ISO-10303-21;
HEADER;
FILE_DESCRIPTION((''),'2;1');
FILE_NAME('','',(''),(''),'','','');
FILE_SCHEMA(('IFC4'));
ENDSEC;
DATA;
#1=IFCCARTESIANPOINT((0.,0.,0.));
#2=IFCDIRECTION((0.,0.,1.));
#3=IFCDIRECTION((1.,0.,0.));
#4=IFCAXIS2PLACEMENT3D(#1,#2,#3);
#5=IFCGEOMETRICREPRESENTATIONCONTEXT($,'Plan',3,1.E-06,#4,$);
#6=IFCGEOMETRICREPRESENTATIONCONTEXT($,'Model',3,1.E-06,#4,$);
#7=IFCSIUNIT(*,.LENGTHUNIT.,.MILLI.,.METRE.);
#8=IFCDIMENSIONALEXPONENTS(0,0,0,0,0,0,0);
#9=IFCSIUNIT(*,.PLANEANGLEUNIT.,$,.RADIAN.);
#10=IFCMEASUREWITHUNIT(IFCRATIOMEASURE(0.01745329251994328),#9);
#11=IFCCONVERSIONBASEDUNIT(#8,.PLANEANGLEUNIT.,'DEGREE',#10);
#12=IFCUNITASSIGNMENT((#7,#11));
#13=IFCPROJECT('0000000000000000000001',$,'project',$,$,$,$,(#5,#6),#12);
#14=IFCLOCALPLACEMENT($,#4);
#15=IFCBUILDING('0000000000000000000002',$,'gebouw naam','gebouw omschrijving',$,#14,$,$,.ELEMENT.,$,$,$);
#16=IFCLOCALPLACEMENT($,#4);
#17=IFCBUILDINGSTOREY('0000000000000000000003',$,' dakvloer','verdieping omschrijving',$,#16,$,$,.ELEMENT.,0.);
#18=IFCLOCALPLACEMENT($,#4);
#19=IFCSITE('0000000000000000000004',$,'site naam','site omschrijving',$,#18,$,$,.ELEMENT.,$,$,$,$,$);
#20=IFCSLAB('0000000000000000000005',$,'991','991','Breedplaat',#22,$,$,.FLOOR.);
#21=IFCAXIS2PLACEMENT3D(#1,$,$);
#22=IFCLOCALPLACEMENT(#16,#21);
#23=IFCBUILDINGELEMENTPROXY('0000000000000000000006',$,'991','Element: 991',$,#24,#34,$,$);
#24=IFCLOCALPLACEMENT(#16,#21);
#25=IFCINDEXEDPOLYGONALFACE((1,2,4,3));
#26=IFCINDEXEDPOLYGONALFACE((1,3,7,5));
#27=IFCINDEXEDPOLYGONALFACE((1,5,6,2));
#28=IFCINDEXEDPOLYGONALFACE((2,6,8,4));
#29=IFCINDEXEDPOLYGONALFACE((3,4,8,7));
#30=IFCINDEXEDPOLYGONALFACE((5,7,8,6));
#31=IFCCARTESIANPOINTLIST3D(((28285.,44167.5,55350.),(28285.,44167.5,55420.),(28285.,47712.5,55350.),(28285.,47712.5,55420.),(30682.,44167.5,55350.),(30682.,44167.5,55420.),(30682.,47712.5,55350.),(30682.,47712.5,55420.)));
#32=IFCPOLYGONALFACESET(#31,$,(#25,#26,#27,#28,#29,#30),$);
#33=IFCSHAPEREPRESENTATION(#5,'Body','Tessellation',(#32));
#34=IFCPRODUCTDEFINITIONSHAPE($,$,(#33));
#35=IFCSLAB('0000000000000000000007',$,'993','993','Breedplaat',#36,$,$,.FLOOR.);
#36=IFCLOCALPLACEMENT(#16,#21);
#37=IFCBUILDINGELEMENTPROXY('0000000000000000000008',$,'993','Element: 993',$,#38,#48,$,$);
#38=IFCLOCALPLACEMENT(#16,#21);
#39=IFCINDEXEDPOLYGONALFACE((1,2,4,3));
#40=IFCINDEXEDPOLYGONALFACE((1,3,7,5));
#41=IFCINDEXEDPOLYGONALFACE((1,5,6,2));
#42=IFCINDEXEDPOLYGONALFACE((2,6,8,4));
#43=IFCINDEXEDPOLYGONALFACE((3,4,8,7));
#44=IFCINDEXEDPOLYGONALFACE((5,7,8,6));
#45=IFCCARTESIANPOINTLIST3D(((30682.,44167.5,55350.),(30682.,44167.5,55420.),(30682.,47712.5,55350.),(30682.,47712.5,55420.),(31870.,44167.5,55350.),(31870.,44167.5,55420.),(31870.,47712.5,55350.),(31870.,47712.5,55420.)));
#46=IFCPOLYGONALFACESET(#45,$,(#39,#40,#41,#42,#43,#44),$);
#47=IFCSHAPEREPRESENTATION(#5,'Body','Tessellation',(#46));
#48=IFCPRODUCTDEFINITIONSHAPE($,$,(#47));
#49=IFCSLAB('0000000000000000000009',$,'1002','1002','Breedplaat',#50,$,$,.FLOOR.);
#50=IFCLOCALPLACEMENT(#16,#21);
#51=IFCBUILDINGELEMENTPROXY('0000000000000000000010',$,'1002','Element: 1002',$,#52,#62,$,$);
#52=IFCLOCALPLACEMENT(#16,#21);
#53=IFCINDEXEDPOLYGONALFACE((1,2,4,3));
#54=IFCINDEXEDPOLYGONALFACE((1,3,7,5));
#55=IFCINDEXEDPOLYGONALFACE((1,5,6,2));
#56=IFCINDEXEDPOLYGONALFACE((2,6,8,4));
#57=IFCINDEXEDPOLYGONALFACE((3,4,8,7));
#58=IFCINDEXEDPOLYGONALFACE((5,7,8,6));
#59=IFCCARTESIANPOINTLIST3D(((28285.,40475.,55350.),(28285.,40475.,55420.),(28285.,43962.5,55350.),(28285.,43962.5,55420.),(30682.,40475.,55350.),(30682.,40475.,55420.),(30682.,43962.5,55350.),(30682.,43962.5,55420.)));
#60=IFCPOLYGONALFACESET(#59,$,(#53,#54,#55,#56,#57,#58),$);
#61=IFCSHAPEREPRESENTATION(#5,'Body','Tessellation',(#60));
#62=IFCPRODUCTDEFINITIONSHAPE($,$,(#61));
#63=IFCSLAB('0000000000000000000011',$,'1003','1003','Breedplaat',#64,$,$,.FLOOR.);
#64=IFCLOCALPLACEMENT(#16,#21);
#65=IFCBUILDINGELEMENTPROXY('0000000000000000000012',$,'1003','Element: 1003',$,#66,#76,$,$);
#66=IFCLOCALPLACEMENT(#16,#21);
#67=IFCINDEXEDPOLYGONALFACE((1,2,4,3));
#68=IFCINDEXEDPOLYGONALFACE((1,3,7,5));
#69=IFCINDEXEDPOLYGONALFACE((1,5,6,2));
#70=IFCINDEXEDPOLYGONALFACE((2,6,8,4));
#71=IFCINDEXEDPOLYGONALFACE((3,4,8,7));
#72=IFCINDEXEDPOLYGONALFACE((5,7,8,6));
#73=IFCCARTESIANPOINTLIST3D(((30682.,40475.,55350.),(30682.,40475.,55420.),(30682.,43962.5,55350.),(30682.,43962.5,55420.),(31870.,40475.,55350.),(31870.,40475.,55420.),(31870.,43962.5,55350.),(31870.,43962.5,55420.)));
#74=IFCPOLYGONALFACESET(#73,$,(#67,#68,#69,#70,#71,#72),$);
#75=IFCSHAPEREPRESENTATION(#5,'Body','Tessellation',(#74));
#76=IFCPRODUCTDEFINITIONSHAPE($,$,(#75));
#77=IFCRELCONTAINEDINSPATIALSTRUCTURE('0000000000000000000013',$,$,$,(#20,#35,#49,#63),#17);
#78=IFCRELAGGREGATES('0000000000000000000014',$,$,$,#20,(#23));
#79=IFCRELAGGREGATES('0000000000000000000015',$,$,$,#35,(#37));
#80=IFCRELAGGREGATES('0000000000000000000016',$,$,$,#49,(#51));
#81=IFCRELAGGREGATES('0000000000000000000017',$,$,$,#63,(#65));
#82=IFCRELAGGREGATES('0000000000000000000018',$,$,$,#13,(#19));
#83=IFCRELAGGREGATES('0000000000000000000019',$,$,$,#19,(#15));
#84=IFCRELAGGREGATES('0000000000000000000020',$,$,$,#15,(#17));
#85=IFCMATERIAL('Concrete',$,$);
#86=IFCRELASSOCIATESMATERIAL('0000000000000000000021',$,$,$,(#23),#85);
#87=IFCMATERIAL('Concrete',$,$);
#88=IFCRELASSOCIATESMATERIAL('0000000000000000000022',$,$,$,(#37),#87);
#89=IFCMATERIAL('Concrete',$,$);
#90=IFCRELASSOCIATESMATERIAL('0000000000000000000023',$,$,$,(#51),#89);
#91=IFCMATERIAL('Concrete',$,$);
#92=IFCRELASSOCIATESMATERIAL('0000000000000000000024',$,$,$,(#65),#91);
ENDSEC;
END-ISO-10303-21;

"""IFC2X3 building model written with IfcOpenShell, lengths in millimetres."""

from ifc_helpers import new_model, entity, si_unit, converted_unit, frame, origin_with_axes, place, context, project, spatial, polyline, outline, extrude, material, element, aggregate, save


model = new_model("IFC2X3")

# Units and contexts
plan_context = context("Plan", 3, precision=1e-06, world=origin_with_axes())
model_context = context("Model", 3, precision=1e-06, world=origin_with_axes())
ifc_project = project(units=[si_unit("LENGTHUNIT", "METRE", prefix="MILLI"), converted_unit("PLANEANGLEUNIT", "DEGREE", entity("IfcRatioMeasure", 0.01745329251994328), si_unit("PLANEANGLEUNIT", "RADIAN"), dimensions=[0, 0, 0, 0, 0, 0, 0])], contexts=[plan_context, model_context])

# Site, building, storey
site_placement = place(None, origin_with_axes())
site = spatial("IfcSite", under=ifc_project, at=site_placement, Name="site naam", Description="site omschrijving", CompositionType="ELEMENT")
building_placement = place(None, origin_with_axes())
building = spatial("IfcBuilding", under=site, at=building_placement, Name="gebouw naam", Description="gebouw omschrijving", CompositionType="ELEMENT")
storey_placement = place(None, origin_with_axes())
storey = spatial("IfcBuildingStorey", under=building, at=storey_placement, Name=" dakvloer", Description="verdieping omschrijving", CompositionType="ELEMENT", Elevation=0.0)

# Slab, building element proxy, openings
slab_1_placement = place(None, frame((28285.0, 47712.5, 55350.0), z_axis=(0.0, 0.0, 1.0), x_axis=(0.0, -1.0, 0.0)))
slab_1 = element("IfcSlab", 1, at=slab_1_placement, inside=storey, Name="991", Description="991", ObjectType="Breedplaat", PredefinedType="FLOOR")
ifc_material_1 = material(Name="Concrete")
proxy_1_placement = place(slab_1_placement, origin_with_axes())
proxy_1 = element("IfcBuildingElementProxy", 2, at=proxy_1_placement, material=ifc_material_1, Name="991", Description="Element: 991", context=plan_context, shape_type="SweptSolid", body=[
    extrude(outline(polyline([(0.0, 0.0), (3545.0, 0.0), (3545.0, 2397.0), (0.0, 2397.0), (0.0, 0.0)])), origin_with_axes(), (0.0, 0.0, 1.0), 70.0),
])
opening_1_placement = place(None, frame((28285.0, 47712.5, 55350.0), z_axis=(0.0, 0.0, 1.0), x_axis=(0.0, -1.0, 0.0)))
element("IfcOpeningElement", 3, at=opening_1_placement, cuts=proxy_1, ObjectType="Opening", context=plan_context, shape_type="SweptSolid", body=[
    extrude(outline(polyline([(-0.1, -0.1), (-0.1, 10.0), (10.0, -0.1), (-0.1, -0.1)])), frame((-1.2, -0.1, -0.1), z_axis=(1.0, 0.0, 0.0), x_axis=(0.0, 1.0, 0.0)), (0.0, 0.0, 1.0), 3547.2),
])
opening_2_placement = place(None, frame((28285.0, 47712.5, 55350.0), z_axis=(0.0, 0.0, 1.0), x_axis=(0.0, -1.0, 0.0)))
element("IfcOpeningElement", 4, at=opening_2_placement, cuts=proxy_1, ObjectType="Opening", context=plan_context, shape_type="SweptSolid", body=[
    extrude(outline(polyline([(-0.1, -0.1), (-0.1, 10.0), (10.0, -0.1), (-0.1, -0.1)])), frame((3546.2, 2397.2, -0.1), z_axis=(-1.0, 0.0, 0.0), x_axis=(0.0, -1.0, 0.0)), (0.0, 0.0, 1.0), 3547.2),
])
aggregate(slab_1, [proxy_1])

# Slab, building element proxy, opening
slab_2_placement = place(None, frame((30682.0, 47712.5, 55350.0), z_axis=(0.0, 0.0, 1.0), x_axis=(0.0, -1.0, 0.0)))
slab_2 = element("IfcSlab", 5, at=slab_2_placement, inside=storey, Name="993", Description="993", ObjectType="Breedplaat", PredefinedType="FLOOR")
ifc_material_2 = material(Name="Concrete")
proxy_2_placement = place(slab_2_placement, origin_with_axes())
proxy_2 = element("IfcBuildingElementProxy", 6, at=proxy_2_placement, material=ifc_material_2, Name="993", Description="Element: 993", context=plan_context, shape_type="SweptSolid", body=[
    extrude(outline(polyline([(3545.0, 0.0), (3545.0, 1188.0), (0.0, 1188.0), (0.0, 0.0), (3545.0, 0.0)])), origin_with_axes(), (0.0, 0.0, 1.0), 70.0),
])
opening_3_placement = place(None, frame((30682.0, 47712.5, 55350.0), z_axis=(0.0, 0.0, 1.0), x_axis=(0.0, -1.0, 0.0)))
element("IfcOpeningElement", 7, at=opening_3_placement, cuts=proxy_2, ObjectType="Opening", context=plan_context, shape_type="SweptSolid", body=[
    extrude(outline(polyline([(-0.1, -0.1), (-0.1, 10.0), (10.0, -0.1), (-0.1, -0.1)])), frame((-1.2, -0.1, -0.1), z_axis=(1.0, 0.0, 0.0), x_axis=(0.0, 1.0, 0.0)), (0.0, 0.0, 1.0), 3547.2),
])
aggregate(slab_2, [proxy_2])

# Slab, building element proxy, openings
slab_3_placement = place(None, frame((28285.0, 43962.5, 55350.0), z_axis=(0.0, 0.0, 1.0), x_axis=(0.0, -1.0, 0.0)))
slab_3 = element("IfcSlab", 8, at=slab_3_placement, inside=storey, Name="1002", Description="1002", ObjectType="Breedplaat", PredefinedType="FLOOR")
ifc_material_3 = material(Name="Concrete")
proxy_3_placement = place(slab_3_placement, origin_with_axes())
proxy_3 = element("IfcBuildingElementProxy", 9, at=proxy_3_placement, material=ifc_material_3, Name="1002", Description="Element: 1002", context=plan_context, shape_type="SweptSolid", body=[
    extrude(outline(polyline([(0.0, 2397.0), (0.0, 0.0), (3487.5, 0.0), (3487.5, 2397.0), (0.0, 2397.0)])), origin_with_axes(), (0.0, 0.0, 1.0), 70.0),
])
opening_4_placement = place(None, frame((28285.0, 43962.5, 55350.0), z_axis=(0.0, 0.0, 1.0), x_axis=(0.0, -1.0, 0.0)))
element("IfcOpeningElement", 10, at=opening_4_placement, cuts=proxy_3, ObjectType="Opening", context=plan_context, shape_type="SweptSolid", body=[
    extrude(outline(polyline([(-0.1, -0.1), (-0.1, 10.0), (10.0, -0.1), (-0.1, -0.1)])), frame((-1.2, -0.1, -0.1), z_axis=(1.0, 0.0, 0.0), x_axis=(0.0, 1.0, 0.0)), (0.0, 0.0, 1.0), 3489.7),
])
opening_5_placement = place(None, frame((28285.0, 43962.5, 55350.0), z_axis=(0.0, 0.0, 1.0), x_axis=(0.0, -1.0, 0.0)))
element("IfcOpeningElement", 11, at=opening_5_placement, cuts=proxy_3, ObjectType="Opening", context=plan_context, shape_type="SweptSolid", body=[
    extrude(outline(polyline([(-0.1, -0.1), (-0.1, 10.0), (10.0, -0.1), (-0.1, -0.1)])), frame((3488.7, 2397.2, -0.1), z_axis=(-1.0, 0.0, 0.0), x_axis=(0.0, -1.0, 0.0)), (0.0, 0.0, 1.0), 3489.7),
])
aggregate(slab_3, [proxy_3])

# Slab, building element proxy, opening
slab_4_placement = place(None, frame((30682.0, 43962.5, 55350.0), z_axis=(0.0, 0.0, 1.0), x_axis=(0.0, -1.0, 0.0)))
slab_4 = element("IfcSlab", 12, at=slab_4_placement, inside=storey, Name="1003", Description="1003", ObjectType="Breedplaat", PredefinedType="FLOOR")
ifc_material_4 = material(Name="Concrete")
proxy_4_placement = place(slab_4_placement, origin_with_axes())
proxy_4 = element("IfcBuildingElementProxy", 13, at=proxy_4_placement, material=ifc_material_4, Name="1003", Description="Element: 1003", context=plan_context, shape_type="SweptSolid", body=[
    extrude(outline(polyline([(0.0, 1188.0), (0.0, 0.0), (3487.5, 0.0), (3487.5, 1188.0), (0.0, 1188.0)])), origin_with_axes(), (0.0, 0.0, 1.0), 70.0),
])
opening_6_placement = place(None, frame((30682.0, 43962.5, 55350.0), z_axis=(0.0, 0.0, 1.0), x_axis=(0.0, -1.0, 0.0)))
element("IfcOpeningElement", 14, at=opening_6_placement, cuts=proxy_4, ObjectType="Opening", context=plan_context, shape_type="SweptSolid", body=[
    extrude(outline(polyline([(-0.1, -0.1), (-0.1, 10.0), (10.0, -0.1), (-0.1, -0.1)])), frame((-1.2, -0.1, -0.1), z_axis=(1.0, 0.0, 0.0), x_axis=(0.0, 1.0, 0.0)), (0.0, 0.0, 1.0), 3489.7),
])
aggregate(slab_4, [proxy_4])

save(model, "model.ifc")
